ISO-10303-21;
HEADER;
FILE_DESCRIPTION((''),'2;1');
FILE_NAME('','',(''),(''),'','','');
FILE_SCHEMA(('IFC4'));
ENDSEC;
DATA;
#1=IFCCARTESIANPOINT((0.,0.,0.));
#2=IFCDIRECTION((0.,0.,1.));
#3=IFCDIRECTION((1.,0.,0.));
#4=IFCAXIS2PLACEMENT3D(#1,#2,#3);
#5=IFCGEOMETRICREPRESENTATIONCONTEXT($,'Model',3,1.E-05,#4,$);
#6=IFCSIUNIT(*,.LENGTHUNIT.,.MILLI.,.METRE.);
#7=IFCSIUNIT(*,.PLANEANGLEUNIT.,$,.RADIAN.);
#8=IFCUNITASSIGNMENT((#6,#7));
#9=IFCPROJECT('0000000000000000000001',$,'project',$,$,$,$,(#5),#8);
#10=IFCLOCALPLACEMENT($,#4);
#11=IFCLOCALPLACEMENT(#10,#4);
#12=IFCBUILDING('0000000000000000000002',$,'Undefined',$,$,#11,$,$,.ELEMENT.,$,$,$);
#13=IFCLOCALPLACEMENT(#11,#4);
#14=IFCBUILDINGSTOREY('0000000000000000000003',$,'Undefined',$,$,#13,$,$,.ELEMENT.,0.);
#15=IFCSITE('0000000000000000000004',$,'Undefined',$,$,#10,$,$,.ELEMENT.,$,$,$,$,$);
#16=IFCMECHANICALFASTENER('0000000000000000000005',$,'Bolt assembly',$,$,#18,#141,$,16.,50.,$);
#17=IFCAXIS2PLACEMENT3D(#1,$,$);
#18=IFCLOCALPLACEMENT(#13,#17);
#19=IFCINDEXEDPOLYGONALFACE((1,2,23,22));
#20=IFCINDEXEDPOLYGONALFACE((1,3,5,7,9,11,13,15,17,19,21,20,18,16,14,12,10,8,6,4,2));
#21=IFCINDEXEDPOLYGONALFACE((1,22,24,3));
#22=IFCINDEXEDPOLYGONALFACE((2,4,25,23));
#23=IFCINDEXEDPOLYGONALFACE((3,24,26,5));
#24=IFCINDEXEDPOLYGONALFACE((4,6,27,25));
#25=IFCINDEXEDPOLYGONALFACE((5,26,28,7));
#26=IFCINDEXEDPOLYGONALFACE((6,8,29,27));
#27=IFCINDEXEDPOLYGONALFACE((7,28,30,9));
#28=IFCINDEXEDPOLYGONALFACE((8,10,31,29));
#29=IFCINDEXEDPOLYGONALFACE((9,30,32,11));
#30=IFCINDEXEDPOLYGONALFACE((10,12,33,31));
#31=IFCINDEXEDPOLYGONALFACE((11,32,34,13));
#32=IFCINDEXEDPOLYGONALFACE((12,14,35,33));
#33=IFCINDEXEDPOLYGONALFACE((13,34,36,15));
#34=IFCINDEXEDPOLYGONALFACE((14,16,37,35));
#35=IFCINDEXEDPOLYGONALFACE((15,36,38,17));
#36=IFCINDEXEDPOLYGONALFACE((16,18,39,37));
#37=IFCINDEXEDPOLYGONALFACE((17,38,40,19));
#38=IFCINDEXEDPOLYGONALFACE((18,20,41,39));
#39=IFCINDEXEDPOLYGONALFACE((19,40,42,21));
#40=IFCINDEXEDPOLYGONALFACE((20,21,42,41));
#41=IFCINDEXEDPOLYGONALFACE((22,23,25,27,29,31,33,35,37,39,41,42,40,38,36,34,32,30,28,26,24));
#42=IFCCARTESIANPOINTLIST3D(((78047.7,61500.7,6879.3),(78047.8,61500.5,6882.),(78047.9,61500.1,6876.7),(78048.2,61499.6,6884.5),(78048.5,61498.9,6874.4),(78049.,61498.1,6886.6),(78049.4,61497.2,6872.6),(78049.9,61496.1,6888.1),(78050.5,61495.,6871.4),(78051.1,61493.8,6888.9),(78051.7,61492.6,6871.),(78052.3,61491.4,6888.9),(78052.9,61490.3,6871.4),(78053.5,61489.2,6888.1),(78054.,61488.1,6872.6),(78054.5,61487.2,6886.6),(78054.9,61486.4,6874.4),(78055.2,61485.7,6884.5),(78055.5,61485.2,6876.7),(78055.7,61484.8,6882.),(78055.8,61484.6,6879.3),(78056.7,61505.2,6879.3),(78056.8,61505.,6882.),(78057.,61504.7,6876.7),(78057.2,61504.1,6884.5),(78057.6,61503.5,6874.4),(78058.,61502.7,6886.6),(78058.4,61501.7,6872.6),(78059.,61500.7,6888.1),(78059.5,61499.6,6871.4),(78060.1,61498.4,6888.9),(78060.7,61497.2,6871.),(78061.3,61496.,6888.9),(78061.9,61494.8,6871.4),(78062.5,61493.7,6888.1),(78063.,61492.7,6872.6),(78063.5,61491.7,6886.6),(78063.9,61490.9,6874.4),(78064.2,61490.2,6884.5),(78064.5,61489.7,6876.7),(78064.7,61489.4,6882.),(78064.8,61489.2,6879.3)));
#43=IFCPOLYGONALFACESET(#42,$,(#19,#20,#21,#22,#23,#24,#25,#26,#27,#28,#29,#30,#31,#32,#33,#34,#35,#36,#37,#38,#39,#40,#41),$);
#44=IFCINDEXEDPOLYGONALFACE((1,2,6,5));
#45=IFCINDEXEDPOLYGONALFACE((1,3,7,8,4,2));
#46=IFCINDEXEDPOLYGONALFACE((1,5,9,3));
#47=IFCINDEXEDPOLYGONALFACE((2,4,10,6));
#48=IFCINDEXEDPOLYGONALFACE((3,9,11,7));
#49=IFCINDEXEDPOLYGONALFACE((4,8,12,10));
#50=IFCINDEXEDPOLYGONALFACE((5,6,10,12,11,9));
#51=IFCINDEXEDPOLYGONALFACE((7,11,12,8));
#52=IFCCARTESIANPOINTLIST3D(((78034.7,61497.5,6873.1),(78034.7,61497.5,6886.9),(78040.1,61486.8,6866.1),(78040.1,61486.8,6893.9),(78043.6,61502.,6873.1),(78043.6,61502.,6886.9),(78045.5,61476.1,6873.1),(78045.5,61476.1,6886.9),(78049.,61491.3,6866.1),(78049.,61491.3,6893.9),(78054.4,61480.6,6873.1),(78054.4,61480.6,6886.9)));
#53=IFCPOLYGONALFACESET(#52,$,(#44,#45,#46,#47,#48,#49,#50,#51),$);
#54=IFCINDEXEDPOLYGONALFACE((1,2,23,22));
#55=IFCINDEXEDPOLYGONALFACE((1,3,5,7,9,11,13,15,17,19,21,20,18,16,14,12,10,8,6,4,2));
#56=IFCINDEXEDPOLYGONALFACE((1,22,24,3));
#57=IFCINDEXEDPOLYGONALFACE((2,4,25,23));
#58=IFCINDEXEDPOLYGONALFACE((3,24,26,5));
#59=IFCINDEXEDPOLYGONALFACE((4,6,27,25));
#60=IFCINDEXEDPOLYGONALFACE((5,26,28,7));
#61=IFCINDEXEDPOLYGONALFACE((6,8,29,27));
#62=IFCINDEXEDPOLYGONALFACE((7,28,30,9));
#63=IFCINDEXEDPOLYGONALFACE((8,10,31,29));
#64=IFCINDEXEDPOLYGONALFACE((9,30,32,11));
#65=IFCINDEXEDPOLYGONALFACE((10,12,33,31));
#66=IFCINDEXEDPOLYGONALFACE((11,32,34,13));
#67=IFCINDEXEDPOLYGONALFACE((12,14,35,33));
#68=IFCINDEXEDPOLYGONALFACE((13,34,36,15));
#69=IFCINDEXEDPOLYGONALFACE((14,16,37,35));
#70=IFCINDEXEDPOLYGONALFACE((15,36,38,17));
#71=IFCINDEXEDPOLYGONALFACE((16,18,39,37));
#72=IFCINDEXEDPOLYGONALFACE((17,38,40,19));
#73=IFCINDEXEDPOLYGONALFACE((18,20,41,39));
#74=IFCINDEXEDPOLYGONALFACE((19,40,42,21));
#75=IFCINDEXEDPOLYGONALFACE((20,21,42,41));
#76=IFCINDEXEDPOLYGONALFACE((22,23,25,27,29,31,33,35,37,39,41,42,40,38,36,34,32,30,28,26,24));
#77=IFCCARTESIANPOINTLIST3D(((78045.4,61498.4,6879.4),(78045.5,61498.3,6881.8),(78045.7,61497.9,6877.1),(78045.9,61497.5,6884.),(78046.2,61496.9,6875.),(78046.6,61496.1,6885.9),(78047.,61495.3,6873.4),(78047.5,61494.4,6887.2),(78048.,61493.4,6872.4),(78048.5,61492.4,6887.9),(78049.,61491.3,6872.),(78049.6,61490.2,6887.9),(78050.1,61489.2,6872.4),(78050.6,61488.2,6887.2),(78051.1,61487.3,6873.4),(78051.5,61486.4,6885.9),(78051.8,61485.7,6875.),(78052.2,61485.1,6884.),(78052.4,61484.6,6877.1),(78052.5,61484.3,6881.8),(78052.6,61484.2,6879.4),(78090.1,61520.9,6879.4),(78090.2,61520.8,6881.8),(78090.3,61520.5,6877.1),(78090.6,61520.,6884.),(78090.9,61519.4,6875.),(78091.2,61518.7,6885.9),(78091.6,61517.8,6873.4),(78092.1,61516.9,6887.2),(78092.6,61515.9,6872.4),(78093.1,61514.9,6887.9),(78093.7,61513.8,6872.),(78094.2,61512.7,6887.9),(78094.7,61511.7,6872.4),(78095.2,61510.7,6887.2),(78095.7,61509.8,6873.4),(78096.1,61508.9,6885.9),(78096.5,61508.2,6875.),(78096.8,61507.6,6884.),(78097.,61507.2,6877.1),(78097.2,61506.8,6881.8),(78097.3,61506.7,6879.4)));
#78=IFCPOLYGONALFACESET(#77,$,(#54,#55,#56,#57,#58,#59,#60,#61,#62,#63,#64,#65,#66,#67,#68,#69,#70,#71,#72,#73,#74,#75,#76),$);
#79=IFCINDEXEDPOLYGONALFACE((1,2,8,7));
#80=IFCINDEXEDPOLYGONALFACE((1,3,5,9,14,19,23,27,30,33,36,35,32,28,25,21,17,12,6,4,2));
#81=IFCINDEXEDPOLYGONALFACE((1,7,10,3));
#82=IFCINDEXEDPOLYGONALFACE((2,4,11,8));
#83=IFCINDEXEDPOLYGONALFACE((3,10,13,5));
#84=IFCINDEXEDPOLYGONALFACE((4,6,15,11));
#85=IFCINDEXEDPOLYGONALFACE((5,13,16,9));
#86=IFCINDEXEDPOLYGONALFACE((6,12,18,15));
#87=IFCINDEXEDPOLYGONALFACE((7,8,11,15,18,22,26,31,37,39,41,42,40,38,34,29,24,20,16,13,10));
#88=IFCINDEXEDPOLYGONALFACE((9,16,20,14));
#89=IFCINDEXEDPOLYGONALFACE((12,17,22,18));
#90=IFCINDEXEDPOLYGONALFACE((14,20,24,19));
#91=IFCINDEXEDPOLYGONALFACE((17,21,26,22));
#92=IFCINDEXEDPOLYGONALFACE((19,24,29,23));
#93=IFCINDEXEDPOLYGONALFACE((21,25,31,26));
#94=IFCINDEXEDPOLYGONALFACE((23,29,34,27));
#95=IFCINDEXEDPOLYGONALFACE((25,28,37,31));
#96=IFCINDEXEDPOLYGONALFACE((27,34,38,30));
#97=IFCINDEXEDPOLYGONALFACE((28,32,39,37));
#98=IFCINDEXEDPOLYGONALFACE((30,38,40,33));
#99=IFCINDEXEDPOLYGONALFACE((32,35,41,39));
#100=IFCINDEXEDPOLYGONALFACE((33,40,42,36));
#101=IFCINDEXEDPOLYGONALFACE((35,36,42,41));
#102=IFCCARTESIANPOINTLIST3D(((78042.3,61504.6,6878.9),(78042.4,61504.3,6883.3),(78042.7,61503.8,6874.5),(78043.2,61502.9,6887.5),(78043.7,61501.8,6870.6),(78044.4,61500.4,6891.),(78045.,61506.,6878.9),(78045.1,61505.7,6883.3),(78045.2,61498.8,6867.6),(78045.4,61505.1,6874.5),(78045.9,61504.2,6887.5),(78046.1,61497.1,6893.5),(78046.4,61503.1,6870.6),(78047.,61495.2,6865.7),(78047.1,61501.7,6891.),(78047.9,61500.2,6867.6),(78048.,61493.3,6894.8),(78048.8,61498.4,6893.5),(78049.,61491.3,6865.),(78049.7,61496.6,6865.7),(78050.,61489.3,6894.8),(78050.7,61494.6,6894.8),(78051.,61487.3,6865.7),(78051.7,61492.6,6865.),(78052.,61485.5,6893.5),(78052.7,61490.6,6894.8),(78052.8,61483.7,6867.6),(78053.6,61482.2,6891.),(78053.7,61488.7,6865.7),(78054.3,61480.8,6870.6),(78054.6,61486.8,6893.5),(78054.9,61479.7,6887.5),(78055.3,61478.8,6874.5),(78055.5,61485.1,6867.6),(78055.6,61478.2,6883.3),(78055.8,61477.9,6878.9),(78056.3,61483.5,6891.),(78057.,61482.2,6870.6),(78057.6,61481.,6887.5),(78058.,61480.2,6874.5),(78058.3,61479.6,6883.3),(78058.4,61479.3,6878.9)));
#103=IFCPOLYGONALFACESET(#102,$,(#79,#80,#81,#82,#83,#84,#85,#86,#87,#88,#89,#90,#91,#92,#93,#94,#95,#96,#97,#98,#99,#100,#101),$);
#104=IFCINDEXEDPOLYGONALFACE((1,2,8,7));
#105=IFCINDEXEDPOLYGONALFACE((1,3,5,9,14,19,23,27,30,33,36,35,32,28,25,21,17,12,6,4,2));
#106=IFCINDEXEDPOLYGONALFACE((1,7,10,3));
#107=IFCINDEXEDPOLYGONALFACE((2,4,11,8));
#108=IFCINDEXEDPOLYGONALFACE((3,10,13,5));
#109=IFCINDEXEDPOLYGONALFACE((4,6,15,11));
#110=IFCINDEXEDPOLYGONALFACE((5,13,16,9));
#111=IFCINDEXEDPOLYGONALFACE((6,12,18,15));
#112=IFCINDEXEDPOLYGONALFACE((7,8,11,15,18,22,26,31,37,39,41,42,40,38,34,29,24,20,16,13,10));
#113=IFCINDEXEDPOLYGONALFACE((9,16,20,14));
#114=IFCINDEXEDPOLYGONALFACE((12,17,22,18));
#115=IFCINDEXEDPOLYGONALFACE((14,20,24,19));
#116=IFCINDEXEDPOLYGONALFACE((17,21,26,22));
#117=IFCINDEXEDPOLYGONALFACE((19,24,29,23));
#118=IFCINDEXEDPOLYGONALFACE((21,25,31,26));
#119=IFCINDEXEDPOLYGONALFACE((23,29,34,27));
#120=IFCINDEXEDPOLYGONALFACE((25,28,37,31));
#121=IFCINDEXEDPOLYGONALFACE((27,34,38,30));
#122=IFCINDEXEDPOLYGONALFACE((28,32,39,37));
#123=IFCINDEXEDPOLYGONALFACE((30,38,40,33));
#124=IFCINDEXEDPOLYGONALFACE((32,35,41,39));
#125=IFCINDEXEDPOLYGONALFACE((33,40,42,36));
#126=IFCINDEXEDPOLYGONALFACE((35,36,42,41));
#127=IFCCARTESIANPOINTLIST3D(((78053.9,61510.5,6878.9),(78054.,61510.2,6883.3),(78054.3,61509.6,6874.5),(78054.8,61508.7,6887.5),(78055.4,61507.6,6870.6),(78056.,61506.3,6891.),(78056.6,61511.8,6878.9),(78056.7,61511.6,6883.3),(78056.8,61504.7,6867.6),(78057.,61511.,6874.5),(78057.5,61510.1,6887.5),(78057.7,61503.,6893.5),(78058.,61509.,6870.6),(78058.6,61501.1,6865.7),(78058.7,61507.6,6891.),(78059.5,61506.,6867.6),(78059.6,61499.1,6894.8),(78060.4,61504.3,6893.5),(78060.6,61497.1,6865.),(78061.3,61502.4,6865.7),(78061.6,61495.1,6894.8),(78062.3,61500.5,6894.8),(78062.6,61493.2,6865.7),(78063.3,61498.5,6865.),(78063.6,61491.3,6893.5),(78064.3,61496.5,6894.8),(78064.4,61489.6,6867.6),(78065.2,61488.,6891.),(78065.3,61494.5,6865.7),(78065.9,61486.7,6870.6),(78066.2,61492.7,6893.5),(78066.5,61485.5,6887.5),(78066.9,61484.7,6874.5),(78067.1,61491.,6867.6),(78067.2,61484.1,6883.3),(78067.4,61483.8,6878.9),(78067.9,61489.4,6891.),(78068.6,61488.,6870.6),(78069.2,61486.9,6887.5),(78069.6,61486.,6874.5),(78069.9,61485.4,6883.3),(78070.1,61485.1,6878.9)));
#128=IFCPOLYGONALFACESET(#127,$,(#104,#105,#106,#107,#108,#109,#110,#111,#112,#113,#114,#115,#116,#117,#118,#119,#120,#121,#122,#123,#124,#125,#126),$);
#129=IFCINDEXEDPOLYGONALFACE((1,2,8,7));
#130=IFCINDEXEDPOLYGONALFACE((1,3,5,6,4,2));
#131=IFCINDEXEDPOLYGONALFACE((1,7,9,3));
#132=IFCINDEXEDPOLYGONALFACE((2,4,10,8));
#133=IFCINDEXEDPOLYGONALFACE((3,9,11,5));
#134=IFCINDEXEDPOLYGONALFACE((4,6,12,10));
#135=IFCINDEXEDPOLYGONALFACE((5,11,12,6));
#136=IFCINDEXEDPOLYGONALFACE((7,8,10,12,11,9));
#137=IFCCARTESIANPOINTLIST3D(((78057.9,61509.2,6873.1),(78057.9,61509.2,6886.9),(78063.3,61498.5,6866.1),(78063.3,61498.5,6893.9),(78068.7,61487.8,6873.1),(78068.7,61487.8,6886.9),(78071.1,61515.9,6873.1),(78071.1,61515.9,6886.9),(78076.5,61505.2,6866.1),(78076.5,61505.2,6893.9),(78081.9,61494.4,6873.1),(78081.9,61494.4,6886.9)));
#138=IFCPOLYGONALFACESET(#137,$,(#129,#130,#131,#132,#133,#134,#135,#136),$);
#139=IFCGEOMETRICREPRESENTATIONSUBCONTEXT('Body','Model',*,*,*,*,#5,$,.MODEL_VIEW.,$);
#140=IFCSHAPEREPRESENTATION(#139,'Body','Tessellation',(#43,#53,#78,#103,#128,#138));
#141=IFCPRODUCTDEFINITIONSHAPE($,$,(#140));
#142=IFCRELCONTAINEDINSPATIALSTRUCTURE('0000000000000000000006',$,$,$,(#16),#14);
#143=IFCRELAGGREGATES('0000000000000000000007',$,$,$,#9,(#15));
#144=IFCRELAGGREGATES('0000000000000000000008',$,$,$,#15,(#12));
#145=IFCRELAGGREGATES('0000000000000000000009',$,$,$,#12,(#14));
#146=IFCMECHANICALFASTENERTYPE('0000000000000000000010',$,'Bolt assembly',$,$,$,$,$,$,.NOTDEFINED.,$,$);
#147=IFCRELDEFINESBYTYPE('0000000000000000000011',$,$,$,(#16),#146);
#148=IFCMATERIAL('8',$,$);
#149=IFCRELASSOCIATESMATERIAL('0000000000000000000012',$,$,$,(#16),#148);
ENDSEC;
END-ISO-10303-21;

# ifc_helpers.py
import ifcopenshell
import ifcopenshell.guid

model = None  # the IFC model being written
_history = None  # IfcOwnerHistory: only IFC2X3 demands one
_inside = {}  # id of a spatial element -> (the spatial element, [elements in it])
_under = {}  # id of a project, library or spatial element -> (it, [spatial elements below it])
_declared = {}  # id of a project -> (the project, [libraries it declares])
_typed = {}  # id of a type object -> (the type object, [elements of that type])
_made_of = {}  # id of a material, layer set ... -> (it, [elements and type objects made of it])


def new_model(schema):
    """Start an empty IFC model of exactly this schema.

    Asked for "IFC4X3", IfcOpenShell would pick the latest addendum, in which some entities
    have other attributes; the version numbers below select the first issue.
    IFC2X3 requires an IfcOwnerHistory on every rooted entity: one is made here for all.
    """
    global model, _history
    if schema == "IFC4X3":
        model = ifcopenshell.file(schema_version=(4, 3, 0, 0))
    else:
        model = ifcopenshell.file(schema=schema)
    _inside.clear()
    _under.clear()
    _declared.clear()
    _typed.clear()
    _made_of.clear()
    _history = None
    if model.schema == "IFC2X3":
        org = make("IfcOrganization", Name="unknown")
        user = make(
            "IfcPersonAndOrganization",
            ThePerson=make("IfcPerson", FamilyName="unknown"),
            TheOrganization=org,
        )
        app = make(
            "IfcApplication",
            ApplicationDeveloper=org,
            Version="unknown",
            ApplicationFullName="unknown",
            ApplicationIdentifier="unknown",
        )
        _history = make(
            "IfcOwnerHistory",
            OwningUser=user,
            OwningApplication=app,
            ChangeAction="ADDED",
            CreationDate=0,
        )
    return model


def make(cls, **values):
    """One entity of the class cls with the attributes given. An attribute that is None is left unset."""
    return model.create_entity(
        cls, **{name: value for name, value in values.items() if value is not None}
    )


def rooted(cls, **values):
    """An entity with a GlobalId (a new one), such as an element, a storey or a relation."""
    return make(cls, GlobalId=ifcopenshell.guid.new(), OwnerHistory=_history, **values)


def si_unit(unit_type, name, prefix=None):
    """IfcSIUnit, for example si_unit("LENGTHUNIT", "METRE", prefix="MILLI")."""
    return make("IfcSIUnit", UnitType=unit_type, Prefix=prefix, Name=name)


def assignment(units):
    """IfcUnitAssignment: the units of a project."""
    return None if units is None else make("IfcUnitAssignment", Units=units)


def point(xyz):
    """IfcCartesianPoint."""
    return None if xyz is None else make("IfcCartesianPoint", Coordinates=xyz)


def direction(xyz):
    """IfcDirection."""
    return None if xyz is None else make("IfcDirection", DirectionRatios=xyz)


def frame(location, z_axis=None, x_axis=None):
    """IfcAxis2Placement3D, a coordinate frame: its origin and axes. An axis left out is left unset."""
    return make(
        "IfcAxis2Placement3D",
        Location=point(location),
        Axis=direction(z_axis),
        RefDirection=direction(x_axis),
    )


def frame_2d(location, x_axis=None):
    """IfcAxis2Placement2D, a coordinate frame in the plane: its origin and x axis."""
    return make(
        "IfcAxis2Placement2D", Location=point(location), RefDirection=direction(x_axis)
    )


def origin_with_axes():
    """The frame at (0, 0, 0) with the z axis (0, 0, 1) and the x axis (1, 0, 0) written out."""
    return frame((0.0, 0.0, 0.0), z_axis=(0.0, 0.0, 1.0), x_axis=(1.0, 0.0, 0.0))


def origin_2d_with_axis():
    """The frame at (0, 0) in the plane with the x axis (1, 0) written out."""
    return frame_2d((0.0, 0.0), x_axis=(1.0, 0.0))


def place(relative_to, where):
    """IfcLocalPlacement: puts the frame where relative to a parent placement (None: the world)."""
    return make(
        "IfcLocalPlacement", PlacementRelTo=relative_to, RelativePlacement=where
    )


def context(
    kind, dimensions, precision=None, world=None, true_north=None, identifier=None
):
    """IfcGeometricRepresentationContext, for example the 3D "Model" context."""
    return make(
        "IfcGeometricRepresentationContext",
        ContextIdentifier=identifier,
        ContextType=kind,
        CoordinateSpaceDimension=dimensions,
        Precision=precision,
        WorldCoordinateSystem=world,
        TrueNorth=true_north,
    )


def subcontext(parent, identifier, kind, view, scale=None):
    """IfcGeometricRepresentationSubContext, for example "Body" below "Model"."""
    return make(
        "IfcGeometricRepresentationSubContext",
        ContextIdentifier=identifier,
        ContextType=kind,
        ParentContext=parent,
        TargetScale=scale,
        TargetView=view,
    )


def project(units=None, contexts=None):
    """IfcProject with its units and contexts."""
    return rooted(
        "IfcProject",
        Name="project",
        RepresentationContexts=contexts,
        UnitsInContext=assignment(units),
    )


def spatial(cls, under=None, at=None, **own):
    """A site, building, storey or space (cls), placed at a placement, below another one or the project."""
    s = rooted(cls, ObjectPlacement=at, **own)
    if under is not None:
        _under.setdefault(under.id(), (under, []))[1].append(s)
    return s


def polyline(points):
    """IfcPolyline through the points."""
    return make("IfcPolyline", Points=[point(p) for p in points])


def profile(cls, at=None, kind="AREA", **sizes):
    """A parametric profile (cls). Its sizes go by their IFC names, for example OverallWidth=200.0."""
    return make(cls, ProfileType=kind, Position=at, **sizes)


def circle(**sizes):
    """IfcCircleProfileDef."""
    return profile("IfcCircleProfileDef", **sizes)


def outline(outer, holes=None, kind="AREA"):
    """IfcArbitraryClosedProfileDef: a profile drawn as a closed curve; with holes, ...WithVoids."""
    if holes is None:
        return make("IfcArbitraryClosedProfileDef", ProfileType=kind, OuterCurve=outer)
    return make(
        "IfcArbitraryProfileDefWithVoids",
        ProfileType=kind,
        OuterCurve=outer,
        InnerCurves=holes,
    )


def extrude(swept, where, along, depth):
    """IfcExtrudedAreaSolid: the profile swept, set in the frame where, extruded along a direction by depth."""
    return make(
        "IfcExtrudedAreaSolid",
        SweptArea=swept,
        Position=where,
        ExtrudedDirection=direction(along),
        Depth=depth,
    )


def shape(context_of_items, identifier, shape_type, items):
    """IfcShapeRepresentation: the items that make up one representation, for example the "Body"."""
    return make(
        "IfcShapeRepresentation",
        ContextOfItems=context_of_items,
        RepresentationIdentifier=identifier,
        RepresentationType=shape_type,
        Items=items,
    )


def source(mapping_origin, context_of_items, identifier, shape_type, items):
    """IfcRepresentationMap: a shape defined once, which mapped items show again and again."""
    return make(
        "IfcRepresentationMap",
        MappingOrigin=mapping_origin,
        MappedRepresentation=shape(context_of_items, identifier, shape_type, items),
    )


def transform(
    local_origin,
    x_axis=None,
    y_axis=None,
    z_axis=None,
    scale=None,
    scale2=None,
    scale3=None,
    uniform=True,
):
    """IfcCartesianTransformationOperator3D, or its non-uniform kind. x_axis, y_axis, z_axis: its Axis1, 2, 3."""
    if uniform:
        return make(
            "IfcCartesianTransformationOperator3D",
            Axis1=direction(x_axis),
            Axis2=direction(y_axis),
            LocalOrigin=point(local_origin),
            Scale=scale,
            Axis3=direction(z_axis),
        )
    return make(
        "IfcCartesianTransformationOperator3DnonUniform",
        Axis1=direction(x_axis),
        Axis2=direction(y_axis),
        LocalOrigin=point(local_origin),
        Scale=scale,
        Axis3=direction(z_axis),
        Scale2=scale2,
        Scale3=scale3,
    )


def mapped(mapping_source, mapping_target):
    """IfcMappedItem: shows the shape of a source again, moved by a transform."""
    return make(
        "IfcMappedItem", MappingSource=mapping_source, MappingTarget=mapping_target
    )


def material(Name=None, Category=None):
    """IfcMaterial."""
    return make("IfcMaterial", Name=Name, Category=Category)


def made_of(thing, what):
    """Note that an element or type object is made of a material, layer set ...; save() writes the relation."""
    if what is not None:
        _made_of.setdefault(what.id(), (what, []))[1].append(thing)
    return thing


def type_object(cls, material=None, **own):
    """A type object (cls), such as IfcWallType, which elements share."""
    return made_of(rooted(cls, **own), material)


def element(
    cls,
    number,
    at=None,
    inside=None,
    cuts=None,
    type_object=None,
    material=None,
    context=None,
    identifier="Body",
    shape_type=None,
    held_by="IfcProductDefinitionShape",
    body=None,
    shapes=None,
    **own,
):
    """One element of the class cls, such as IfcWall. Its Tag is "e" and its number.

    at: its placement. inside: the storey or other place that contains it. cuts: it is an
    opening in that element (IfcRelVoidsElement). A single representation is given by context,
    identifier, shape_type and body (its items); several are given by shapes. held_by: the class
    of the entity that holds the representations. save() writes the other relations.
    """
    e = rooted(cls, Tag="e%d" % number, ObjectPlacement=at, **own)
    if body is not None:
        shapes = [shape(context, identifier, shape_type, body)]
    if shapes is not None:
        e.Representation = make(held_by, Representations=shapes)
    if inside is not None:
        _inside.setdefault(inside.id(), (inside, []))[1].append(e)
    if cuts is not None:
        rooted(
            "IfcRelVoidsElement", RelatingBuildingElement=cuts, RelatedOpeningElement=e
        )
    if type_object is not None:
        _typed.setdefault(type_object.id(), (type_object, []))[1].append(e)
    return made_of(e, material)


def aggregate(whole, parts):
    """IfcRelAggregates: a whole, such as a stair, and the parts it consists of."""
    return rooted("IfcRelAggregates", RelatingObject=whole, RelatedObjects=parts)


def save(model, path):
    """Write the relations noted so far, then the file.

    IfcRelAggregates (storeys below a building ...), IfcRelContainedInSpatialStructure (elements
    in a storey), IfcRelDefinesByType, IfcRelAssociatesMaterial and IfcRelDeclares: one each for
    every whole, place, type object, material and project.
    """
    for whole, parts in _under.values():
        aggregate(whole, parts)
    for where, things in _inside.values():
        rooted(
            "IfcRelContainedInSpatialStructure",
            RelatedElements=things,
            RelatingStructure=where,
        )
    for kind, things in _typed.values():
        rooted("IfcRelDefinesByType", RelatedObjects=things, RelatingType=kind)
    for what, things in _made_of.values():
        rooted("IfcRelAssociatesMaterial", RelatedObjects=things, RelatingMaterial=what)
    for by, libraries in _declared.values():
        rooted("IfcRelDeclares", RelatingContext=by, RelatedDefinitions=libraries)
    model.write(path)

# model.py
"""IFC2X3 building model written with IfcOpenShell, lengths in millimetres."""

from ifc_helpers import new_model, si_unit, frame, origin_with_axes, origin_2d_with_axis, place, context, subcontext, project, spatial, polyline, circle, outline, extrude, source, transform, mapped, material, type_object, element, save


model = new_model("IFC2X3")

# Units and contexts
model_context = context("Model", 3, precision=1e-05, world=origin_with_axes())
body_context = subcontext(model_context, "Body", "Model", "MODEL_VIEW")
ifc_project = project(units=[si_unit("LENGTHUNIT", "METRE", prefix="MILLI"), si_unit("PLANEANGLEUNIT", "RADIAN")], contexts=[model_context])

# Site, building, storey
site_placement = place(None, origin_with_axes())
site = spatial("IfcSite", under=ifc_project, at=site_placement, Name="Undefined", CompositionType="ELEMENT")
building_placement = place(site_placement, origin_with_axes())
building = spatial("IfcBuilding", under=site, at=building_placement, Name="Undefined", CompositionType="ELEMENT")
storey_placement = place(building_placement, origin_with_axes())
storey = spatial("IfcBuildingStorey", under=building, at=storey_placement, Name="Undefined", CompositionType="ELEMENT", Elevation=0.0)

# Mechanical fastener
ifc_material_1 = material(Name="8")
mechanical_fastener_type = type_object("IfcMechanicalFastenerType", Name="Bolt assembly")
shared_shape_1 = source(origin_with_axes(), body_context, "Body", "SweptSolid", [
    extrude(circle(Radius=9.0, at=origin_2d_with_axis()), frame((0.0, 0.3, 0.0), z_axis=(0.0, 1.0, 0.0), x_axis=(1.0, 0.0, 0.0)), (0.0, 0.0, 1.0), 10.1),
    extrude(outline(polyline([(13.9, 0.0), (6.9, 12.0), (-6.9, 12.0), (-13.9, 0.0), (-6.9, -12.0), (6.9, -12.0), (13.9, 0.0)])), frame((0.0, -12.7, 0.0), z_axis=(0.0, 1.0, 0.0), x_axis=(1.0, 0.0, 0.0)), (0.0, 0.0, 1.0), 10.0),
    extrude(circle(Radius=8.0, at=origin_2d_with_axis()), frame((0.0, -2.7, 0.0), z_axis=(0.0, 1.0, 0.0), x_axis=(1.0, 0.0, 0.0)), (0.0, 0.0, 1.0), 50.0),
    extrude(circle(Radius=15.0, at=origin_2d_with_axis()), frame((0.0, -2.7, 0.0), z_axis=(0.0, 1.0, 0.0), x_axis=(1.0, 0.0, 0.0)), (0.0, 0.0, 1.0), 3.0),
    extrude(circle(Radius=15.0, at=origin_2d_with_axis()), frame((0.0, 10.3, 0.0), z_axis=(0.0, 1.0, 0.0), x_axis=(1.0, 0.0, 0.0)), (0.0, 0.0, 1.0), 3.0),
    extrude(outline(polyline([(13.9, 0.0), (6.9, 12.0), (-6.9, 12.0), (-13.9, 0.0), (-6.9, -12.0), (6.9, -12.0), (13.9, 0.0)])), frame((0.0, 13.3, 0.0), z_axis=(0.0, 1.0, 0.0), x_axis=(1.0, 0.0, 0.0)), (0.0, 0.0, 1.0), 14.8),
])
mechanical_fastener_1_placement = place(storey_placement, frame((78051.4, 61492.5, 6880.0), z_axis=(0.45041, -0.892822, -0.000127), x_axis=(-0.000057, 0.000114, -1.0)))
element("IfcMechanicalFastener", 1, at=mechanical_fastener_1_placement, inside=storey, type_object=mechanical_fastener_type, material=ifc_material_1, Name="Bolt assembly", NominalDiameter=16.0, NominalLength=50.0, context=body_context, shape_type="MappedRepresentation", body=[
    mapped(shared_shape_1, transform((0.0, 0.0, 0.0))),
])

save(model, "model.ifc")
